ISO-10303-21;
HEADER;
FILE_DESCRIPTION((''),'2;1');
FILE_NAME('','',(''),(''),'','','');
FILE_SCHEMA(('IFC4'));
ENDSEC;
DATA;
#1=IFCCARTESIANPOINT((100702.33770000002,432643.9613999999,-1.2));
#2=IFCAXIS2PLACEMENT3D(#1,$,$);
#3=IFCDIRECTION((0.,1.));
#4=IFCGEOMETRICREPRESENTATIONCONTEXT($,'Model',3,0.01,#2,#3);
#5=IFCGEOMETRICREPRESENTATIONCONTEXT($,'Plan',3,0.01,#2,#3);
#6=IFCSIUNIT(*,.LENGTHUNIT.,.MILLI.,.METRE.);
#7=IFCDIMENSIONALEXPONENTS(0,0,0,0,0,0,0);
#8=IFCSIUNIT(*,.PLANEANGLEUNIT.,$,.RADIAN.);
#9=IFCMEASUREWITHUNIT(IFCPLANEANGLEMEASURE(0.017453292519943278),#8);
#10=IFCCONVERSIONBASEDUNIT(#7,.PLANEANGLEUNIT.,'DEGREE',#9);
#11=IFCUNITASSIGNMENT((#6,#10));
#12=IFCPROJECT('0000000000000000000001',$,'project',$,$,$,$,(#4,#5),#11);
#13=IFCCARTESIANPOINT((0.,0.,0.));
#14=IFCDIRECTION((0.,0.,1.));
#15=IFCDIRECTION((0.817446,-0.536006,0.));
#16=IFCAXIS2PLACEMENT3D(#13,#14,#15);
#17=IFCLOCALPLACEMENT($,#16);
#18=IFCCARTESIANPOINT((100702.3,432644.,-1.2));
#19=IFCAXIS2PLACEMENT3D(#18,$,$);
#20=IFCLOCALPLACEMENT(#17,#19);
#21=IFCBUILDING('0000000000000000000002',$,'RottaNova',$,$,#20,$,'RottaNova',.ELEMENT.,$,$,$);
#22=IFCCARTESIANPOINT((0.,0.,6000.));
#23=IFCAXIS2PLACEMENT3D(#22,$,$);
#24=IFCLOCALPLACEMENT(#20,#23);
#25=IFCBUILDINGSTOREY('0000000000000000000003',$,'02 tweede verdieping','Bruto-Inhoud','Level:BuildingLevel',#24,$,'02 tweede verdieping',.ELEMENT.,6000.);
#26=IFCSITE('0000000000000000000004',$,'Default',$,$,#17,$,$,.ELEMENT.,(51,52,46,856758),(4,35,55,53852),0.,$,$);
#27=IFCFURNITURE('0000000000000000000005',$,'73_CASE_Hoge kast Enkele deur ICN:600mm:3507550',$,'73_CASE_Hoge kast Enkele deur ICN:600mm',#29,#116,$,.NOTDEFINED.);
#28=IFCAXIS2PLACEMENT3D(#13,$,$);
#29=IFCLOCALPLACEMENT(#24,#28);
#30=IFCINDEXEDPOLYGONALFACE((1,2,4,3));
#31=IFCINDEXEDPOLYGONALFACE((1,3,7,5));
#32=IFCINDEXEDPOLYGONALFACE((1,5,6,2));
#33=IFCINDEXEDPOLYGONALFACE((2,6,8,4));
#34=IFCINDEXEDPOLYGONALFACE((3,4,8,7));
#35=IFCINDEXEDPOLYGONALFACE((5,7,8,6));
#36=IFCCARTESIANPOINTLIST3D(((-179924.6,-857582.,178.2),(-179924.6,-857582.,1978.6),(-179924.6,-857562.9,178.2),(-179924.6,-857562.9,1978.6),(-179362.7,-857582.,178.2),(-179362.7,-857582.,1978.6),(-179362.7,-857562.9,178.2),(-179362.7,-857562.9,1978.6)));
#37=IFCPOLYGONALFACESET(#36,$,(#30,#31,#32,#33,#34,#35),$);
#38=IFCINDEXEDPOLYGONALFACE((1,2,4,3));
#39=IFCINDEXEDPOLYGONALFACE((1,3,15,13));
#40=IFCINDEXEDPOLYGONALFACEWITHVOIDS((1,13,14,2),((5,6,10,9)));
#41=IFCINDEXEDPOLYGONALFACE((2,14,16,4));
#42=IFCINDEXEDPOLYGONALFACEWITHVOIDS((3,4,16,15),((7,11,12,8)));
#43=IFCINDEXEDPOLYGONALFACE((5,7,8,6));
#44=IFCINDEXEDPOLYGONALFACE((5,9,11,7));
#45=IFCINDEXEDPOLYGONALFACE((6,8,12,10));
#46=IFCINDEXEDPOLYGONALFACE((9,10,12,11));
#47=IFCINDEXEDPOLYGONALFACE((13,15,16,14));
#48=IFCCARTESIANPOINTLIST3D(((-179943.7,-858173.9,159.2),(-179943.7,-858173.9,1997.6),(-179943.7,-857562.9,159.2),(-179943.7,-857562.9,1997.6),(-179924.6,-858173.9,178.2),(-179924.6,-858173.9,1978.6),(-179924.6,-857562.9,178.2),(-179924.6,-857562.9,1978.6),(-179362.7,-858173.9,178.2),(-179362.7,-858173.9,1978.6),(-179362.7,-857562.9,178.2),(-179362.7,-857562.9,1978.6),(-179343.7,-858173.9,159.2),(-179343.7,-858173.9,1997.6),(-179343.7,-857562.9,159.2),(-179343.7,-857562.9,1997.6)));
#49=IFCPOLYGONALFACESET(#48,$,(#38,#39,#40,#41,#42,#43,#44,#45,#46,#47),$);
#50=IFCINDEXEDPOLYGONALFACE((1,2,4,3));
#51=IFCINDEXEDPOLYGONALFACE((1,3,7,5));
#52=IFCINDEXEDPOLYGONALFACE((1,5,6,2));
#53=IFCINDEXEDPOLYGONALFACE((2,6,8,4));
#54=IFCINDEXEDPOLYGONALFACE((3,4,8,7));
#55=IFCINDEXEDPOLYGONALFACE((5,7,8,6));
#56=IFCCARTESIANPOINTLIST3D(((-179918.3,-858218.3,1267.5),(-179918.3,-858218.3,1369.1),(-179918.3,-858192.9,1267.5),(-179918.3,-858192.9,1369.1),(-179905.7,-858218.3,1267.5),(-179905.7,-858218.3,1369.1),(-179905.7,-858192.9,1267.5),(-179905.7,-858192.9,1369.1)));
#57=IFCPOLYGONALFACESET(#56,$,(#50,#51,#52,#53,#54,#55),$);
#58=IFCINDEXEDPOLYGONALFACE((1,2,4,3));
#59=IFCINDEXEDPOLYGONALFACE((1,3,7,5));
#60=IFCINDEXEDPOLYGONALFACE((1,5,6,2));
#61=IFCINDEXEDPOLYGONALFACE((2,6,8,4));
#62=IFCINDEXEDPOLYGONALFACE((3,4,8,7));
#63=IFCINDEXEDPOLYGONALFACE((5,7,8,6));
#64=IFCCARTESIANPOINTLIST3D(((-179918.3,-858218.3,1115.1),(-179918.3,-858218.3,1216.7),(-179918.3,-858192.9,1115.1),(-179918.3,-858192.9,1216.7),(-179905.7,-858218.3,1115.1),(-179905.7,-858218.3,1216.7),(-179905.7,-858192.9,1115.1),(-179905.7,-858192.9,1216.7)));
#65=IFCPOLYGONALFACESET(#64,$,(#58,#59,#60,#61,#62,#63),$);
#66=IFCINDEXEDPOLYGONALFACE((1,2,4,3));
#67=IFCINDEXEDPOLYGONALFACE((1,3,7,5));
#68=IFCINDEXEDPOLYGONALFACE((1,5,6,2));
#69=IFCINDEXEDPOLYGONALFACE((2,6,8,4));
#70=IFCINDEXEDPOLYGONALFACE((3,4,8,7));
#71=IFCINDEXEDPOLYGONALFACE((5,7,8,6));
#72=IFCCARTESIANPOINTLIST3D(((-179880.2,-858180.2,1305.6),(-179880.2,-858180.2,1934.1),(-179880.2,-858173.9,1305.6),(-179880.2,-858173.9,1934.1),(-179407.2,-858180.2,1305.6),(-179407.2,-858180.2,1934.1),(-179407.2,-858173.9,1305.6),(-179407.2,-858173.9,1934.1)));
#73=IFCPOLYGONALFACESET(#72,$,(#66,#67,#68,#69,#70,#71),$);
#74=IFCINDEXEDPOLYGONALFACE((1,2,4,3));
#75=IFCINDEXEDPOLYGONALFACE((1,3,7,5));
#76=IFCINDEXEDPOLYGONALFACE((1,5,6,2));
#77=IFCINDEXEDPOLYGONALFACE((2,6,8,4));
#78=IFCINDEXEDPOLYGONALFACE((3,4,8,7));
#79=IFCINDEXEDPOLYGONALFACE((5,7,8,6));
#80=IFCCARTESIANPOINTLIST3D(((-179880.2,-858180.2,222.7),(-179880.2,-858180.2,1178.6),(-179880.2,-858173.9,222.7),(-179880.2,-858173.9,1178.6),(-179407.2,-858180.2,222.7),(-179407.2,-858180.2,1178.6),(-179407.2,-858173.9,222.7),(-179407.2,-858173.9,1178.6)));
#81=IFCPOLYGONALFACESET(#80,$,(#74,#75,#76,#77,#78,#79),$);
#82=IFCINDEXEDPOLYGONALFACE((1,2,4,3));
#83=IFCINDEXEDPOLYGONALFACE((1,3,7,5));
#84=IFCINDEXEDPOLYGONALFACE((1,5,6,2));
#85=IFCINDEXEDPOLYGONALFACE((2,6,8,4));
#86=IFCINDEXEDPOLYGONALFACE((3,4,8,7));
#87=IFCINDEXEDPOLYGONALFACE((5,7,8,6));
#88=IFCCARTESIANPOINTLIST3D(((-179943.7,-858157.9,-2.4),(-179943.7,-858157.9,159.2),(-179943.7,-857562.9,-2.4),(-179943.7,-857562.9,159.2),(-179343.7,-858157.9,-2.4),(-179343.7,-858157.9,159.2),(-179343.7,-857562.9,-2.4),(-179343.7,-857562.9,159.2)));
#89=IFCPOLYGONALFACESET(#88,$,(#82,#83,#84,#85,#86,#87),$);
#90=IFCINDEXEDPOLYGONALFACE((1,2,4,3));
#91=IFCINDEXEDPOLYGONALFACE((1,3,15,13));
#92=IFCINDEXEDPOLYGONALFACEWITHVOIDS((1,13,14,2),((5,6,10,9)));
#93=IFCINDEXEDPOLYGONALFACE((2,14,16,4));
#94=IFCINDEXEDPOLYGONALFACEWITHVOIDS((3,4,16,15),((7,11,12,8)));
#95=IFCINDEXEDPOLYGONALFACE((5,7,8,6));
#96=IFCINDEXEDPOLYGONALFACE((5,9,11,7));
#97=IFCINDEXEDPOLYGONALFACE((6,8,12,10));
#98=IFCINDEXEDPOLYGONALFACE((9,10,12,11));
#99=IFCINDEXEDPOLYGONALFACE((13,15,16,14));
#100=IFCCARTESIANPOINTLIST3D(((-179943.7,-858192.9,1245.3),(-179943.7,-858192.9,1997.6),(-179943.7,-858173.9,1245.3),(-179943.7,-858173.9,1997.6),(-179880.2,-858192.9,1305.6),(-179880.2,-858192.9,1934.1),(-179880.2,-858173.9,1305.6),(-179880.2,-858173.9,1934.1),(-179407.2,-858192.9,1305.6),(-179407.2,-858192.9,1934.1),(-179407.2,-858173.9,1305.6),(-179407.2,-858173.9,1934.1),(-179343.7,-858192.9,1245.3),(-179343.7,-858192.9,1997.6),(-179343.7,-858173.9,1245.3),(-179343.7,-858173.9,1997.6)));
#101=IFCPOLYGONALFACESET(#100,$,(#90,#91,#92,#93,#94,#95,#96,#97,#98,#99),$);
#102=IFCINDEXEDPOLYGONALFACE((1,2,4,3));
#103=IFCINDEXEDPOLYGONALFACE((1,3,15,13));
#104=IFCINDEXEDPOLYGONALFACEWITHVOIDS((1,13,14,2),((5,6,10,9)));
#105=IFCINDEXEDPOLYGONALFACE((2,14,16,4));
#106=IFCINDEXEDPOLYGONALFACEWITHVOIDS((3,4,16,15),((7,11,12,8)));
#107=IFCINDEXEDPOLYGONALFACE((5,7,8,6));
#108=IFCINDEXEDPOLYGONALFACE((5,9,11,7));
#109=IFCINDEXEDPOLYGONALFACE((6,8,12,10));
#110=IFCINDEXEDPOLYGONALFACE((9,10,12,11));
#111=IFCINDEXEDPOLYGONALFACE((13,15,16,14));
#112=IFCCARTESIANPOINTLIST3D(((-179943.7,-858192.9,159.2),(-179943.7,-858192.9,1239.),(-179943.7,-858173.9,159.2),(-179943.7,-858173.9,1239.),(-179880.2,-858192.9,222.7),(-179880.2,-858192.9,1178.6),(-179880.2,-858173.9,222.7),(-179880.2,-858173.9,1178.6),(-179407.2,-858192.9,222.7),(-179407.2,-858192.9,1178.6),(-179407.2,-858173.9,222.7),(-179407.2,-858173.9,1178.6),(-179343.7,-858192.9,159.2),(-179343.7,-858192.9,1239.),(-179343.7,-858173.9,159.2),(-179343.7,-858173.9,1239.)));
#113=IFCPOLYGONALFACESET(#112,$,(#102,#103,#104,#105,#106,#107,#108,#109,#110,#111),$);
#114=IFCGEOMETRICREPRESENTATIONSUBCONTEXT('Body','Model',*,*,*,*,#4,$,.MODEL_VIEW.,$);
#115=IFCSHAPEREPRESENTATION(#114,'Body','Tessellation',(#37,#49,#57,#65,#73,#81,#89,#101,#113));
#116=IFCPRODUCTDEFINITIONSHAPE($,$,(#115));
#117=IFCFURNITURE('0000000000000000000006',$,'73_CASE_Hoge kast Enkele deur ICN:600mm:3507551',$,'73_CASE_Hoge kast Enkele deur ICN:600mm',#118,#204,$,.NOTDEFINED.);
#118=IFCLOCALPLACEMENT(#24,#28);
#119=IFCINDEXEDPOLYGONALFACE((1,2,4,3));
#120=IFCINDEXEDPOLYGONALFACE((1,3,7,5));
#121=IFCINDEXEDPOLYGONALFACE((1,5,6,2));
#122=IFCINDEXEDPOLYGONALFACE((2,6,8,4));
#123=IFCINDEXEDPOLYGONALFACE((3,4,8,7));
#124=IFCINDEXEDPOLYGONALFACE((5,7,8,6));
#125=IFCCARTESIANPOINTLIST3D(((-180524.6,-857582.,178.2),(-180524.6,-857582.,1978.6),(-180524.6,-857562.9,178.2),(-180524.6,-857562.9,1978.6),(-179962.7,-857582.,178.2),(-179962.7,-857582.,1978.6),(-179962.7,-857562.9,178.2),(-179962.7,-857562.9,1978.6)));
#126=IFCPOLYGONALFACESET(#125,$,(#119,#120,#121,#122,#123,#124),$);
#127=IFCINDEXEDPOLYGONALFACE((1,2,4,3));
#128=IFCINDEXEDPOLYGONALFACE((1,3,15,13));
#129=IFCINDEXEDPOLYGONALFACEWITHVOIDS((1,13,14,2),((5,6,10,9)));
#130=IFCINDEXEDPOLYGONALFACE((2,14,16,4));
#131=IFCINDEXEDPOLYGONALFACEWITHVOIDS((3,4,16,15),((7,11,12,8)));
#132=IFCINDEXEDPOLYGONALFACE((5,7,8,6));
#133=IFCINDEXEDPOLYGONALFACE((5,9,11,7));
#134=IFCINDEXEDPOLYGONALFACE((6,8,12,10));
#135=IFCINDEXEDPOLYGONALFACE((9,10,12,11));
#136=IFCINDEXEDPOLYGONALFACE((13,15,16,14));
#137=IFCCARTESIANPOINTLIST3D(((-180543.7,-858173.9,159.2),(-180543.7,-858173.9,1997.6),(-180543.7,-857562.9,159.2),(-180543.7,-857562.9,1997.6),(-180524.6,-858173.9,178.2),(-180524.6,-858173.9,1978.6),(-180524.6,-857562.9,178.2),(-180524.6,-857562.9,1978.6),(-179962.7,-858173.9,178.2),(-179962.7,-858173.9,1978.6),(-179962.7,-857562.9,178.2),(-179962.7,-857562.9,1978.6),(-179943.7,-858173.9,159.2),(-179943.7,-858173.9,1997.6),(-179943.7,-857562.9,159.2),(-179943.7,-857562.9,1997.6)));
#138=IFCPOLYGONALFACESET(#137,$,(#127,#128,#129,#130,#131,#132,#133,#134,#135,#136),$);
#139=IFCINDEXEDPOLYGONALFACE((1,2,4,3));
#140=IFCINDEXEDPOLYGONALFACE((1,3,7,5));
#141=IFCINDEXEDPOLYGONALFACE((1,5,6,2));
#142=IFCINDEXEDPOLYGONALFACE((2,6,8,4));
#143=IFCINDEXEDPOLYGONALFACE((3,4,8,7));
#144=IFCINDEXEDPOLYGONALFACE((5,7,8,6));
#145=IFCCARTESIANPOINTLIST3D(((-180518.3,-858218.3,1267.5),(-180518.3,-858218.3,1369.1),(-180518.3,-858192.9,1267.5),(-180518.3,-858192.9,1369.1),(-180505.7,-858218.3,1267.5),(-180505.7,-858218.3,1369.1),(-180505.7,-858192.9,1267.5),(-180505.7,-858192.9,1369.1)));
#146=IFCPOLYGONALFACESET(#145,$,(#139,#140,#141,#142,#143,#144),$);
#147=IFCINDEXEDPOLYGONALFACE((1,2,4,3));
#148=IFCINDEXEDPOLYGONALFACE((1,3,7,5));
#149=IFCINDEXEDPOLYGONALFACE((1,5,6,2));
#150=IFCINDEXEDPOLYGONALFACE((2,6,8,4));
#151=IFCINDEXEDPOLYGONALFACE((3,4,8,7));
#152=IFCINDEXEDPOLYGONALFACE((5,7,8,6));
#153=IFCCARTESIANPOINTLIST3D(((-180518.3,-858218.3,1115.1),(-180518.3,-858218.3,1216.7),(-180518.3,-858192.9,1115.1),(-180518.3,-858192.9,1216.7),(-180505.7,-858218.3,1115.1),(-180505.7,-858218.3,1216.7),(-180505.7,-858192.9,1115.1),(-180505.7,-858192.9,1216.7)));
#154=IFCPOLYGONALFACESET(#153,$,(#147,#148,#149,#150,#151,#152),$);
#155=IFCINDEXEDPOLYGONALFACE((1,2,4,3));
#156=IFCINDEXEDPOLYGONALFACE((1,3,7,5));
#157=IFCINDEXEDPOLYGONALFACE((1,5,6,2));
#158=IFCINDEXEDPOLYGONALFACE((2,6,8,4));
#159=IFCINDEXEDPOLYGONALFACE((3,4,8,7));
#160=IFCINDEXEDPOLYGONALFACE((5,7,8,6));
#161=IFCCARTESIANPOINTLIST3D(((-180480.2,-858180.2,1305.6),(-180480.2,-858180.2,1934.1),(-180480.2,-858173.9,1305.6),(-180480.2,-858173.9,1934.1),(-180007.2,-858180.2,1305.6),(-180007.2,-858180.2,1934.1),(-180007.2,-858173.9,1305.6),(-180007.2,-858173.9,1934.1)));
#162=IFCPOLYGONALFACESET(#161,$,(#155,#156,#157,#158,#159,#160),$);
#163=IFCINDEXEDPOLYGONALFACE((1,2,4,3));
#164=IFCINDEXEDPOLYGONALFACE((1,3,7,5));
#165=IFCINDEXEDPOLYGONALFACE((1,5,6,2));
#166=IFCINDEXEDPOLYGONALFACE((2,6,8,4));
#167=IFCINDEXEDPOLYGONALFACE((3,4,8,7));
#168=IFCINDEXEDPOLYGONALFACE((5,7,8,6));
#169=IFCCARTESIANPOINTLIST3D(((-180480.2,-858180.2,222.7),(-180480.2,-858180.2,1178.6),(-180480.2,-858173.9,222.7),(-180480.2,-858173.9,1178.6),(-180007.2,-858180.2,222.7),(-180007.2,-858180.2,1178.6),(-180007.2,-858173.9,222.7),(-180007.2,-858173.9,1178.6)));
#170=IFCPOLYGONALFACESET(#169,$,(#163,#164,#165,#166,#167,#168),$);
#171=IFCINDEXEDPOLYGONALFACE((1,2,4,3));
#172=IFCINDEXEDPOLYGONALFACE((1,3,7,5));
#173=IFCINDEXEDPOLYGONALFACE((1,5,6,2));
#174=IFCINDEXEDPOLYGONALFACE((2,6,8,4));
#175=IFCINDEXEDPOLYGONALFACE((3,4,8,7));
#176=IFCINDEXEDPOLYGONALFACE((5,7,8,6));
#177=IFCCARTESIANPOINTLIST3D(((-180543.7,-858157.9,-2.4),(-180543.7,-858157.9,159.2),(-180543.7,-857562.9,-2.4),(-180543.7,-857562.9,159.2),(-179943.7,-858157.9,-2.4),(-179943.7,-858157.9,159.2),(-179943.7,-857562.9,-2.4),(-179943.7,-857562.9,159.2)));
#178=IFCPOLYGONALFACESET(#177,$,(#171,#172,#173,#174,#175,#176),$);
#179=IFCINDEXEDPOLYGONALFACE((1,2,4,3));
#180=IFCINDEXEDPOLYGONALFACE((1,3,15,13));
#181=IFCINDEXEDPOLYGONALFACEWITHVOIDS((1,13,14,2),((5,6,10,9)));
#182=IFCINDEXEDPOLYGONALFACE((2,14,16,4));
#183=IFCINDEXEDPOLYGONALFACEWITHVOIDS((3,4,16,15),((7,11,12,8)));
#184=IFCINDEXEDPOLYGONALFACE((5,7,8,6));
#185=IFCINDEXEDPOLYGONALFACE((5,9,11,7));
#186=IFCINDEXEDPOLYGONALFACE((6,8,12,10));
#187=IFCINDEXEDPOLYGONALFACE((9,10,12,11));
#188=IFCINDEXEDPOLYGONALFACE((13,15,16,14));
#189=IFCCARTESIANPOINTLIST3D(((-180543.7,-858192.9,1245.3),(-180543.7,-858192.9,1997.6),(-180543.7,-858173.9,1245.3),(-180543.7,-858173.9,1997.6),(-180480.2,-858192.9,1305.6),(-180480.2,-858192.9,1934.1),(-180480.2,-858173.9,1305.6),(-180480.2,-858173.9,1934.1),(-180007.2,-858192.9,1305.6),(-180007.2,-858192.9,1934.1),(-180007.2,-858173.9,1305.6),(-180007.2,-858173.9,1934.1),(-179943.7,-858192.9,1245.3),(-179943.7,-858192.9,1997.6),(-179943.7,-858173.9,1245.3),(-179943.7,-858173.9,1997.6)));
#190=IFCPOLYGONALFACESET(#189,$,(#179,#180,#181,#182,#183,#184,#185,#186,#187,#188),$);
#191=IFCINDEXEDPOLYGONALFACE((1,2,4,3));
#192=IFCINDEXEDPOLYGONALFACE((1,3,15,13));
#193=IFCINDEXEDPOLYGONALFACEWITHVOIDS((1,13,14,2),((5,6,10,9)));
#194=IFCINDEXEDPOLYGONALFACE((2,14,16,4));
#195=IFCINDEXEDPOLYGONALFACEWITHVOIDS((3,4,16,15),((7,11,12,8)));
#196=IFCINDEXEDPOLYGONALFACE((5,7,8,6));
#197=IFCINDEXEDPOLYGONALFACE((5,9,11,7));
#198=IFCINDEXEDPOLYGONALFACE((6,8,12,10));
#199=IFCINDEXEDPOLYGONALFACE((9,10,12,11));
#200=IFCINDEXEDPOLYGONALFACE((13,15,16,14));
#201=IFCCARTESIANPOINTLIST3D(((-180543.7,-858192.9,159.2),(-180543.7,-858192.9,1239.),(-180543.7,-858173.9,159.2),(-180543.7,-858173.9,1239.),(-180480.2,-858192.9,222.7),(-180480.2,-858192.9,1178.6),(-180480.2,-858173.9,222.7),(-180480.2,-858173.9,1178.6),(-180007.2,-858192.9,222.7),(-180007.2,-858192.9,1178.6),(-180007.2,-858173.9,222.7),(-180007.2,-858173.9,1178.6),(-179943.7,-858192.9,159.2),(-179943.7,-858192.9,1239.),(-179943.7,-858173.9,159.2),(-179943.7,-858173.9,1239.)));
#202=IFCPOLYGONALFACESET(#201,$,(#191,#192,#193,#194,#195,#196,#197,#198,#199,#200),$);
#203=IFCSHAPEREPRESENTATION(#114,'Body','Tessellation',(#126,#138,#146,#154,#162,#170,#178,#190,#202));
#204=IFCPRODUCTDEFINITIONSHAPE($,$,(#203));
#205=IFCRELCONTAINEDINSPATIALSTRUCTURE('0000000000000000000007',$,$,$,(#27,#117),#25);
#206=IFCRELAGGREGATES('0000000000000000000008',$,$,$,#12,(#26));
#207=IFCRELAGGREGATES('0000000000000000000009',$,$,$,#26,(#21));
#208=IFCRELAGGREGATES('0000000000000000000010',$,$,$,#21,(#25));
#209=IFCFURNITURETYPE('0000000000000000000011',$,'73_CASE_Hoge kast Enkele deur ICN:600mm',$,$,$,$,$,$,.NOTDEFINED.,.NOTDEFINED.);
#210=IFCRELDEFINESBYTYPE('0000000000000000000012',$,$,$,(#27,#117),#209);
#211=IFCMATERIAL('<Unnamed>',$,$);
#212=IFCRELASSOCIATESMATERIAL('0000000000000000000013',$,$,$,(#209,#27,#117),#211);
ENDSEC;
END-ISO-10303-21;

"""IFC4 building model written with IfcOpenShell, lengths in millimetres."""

from ifc_helpers import new_model, entity, si_unit, converted_unit, direction, frame, place, context, subcontext, project, spatial, indexed_curve, outline, extrude, source, transform, mapped, material, type_object, type_shapes, element, save


model = new_model("IFC4")

# Units and contexts
model_context = context("Model", 3, precision=0.01, world=frame((100702.33770000002, 432643.9613999999, -1.2)), true_north=direction((0.0, 1.0)))
plan_context = context("Plan", 3, precision=0.01, world=frame((100702.33770000002, 432643.9613999999, -1.2)), true_north=direction((0.0, 1.0)))
body_context = subcontext(model_context, "Body", "Model", "MODEL_VIEW")
ifc_project = project(units=[si_unit("LENGTHUNIT", "METRE", prefix="MILLI"), converted_unit("PLANEANGLEUNIT", "DEGREE", entity("IfcPlaneAngleMeasure", 0.017453292519943278), si_unit("PLANEANGLEUNIT", "RADIAN"), dimensions=[0, 0, 0, 0, 0, 0, 0])], contexts=[model_context, plan_context])

# Site, building, storey
site_placement = place(None, frame((0.0, 0.0, 0.0), z_axis=(0.0, 0.0, 1.0), x_axis=(0.817446, -0.536006, 0.0)))
site = spatial("IfcSite", under=ifc_project, at=site_placement, Name="Default", CompositionType="ELEMENT", RefLatitude=(51, 52, 46, 856758), RefLongitude=(4, 35, 55, 53852), RefElevation=0.0)
building_placement = place(site_placement, frame((100702.3, 432644.0, -1.2)))
building = spatial("IfcBuilding", under=site, at=building_placement, Name="RottaNova", LongName="RottaNova", CompositionType="ELEMENT")
storey_placement = place(building_placement, frame((0.0, 0.0, 6000.0)))
storey = spatial("IfcBuildingStorey", under=building, at=storey_placement, Name="02 tweede verdieping", Description="Bruto-Inhoud", ObjectType="Level:BuildingLevel", LongName="02 tweede verdieping", CompositionType="ELEMENT", Elevation=6000.0)

# Furniture
ifc_material_1 = material(Name="<Unnamed>")
furniture_type = type_object("IfcFurnitureType", Name="73_CASE_Hoge kast Enkele deur ICN:600mm", AssemblyPlace="NOTDEFINED", PredefinedType="NOTDEFINED", material=ifc_material_1)
shared_shape_1 = source(frame((100702.3, 432644.0, -1.2)), body_context, "Body", "SweptSolid", [
    extrude(outline(indexed_curve([(-280.9, -9.5), (280.9, -9.5), (280.9, 9.5), (-280.9, 9.5), (-280.9, -9.5)], self_intersect=False)), frame((18.7, 9.5, 180.6), z_axis=(0.0, 0.0, 1.0), x_axis=(-1.0, 0.0, 0.0)), (0.0, 0.0, 1.0), 1800.3),
    extrude(outline(indexed_curve([(-300.0, -919.2), (300.0, -919.2), (300.0, 919.2), (-300.0, 919.2), (-300.0, -919.2)], self_intersect=False), holes=[indexed_curve([(-280.9, 900.2), (281.0, 900.2), (281.0, -900.2), (-280.9, -900.2), (-280.9, 900.2)], self_intersect=False)]), frame((18.7, 0.0, 1080.8), z_axis=(0.0, 1.0, 0.0), x_axis=(-1.0, 0.0, 0.0)), (0.0, 0.0, 1.0), 610.9),
    extrude(outline(indexed_curve([(-6.3, -12.7), (6.3, -12.7), (6.3, 12.7), (-6.3, 12.7), (-6.3, -12.7)], self_intersect=False)), frame((287.1, 642.7, 1269.9), z_axis=(0.0, 0.0, 1.0), x_axis=(-1.0, 0.0, 0.0)), (0.0, 0.0, 1.0), 101.6),
    extrude(outline(indexed_curve([(-6.3, -12.7), (6.3, -12.7), (6.3, 12.7), (-6.3, 12.7), (-6.3, -12.7)], self_intersect=False)), frame((287.1, 642.7, 1117.5), z_axis=(0.0, 0.0, 1.0), x_axis=(-1.0, 0.0, 0.0)), (0.0, 0.0, 1.0), 101.6),
    extrude(outline(indexed_curve([(-236.5, -3.2), (236.5, -3.2), (236.5, 3.2), (-236.5, 3.2), (-236.5, -3.2)], self_intersect=False)), frame((18.7, 614.1, 1308.0), z_axis=(0.0, 0.0, 1.0), x_axis=(-1.0, 0.0, 0.0)), (0.0, 0.0, 1.0), 628.5),
    extrude(outline(indexed_curve([(-236.5, -3.2), (236.5, -3.2), (236.5, 3.2), (-236.5, 3.2), (-236.5, -3.2)], self_intersect=False)), frame((18.7, 614.1, 225.1), z_axis=(0.0, 0.0, 1.0), x_axis=(-1.0, 0.0, 0.0)), (0.0, 0.0, 1.0), 956.0),
    extrude(outline(indexed_curve([(-297.5, -300.0), (297.5, -300.0), (297.5, 300.0), (-297.5, 300.0), (-297.5, -300.0)], self_intersect=False)), frame((18.7, 297.5, 0.0), z_axis=(0.0, 0.0, 1.0), x_axis=(0.0, 1.0, 0.0)), (0.0, 0.0, 1.0), 161.6),
    extrude(outline(indexed_curve([(-376.1, -300.0), (376.1, -300.0), (376.1, 300.0), (-376.1, 300.0), (-376.1, -300.0)], self_intersect=False), holes=[indexed_curve([(-312.6, -236.5), (-312.6, 236.5), (315.8, 236.5), (315.8, -236.5), (-312.6, -236.5)], self_intersect=False)]), frame((18.7, 610.9, 1623.9), z_axis=(0.0, 1.0, 0.0), x_axis=(0.0, 0.0, -1.0)), (0.0, 0.0, 1.0), 19.1),
    extrude(outline(indexed_curve([(-300.0, -539.9), (300.0, -539.9), (300.0, 539.9), (-300.0, 539.9), (-300.0, -539.9)], self_intersect=False), holes=[indexed_curve([(-236.5, 479.6), (236.5, 479.6), (236.5, -476.4), (-236.5, -476.4), (-236.5, 479.6)], self_intersect=False)]), frame((18.7, 610.9, 701.5), z_axis=(0.0, 1.0, 0.0), x_axis=(-1.0, 0.0, 0.0)), (0.0, 0.0, 1.0), 19.1),
])
type_shapes(furniture_type, [shared_shape_1])
for number, where, z_axis, x_axis, name in (
    (1, (21779.7, 7725.0, 0.0), (0.0, 0.0, 1.0), (-1.0, 0.0, 0.0), "73_CASE_Hoge kast Enkele deur ICN:600mm:3507550"),
    (2, (21179.7, 7725.0, 0.0), (0.0, 0.0, 1.0), (-1.0, 0.0, 0.0), "73_CASE_Hoge kast Enkele deur ICN:600mm:3507551"),
):
    element("IfcFurniture", number, at=place(storey_placement, frame(where, z_axis=z_axis, x_axis=x_axis)), inside=storey, type_object=furniture_type, material=ifc_material_1, Name=name, ObjectType="73_CASE_Hoge kast Enkele deur ICN:600mm", PredefinedType="NOTDEFINED", context=body_context, shape_type="MappedRepresentation", body=[
        mapped(shared_shape_1, transform((100702.3, 432644.0, -1.2), scale=1.0)),
    ])

save(model, "model.ifc")
